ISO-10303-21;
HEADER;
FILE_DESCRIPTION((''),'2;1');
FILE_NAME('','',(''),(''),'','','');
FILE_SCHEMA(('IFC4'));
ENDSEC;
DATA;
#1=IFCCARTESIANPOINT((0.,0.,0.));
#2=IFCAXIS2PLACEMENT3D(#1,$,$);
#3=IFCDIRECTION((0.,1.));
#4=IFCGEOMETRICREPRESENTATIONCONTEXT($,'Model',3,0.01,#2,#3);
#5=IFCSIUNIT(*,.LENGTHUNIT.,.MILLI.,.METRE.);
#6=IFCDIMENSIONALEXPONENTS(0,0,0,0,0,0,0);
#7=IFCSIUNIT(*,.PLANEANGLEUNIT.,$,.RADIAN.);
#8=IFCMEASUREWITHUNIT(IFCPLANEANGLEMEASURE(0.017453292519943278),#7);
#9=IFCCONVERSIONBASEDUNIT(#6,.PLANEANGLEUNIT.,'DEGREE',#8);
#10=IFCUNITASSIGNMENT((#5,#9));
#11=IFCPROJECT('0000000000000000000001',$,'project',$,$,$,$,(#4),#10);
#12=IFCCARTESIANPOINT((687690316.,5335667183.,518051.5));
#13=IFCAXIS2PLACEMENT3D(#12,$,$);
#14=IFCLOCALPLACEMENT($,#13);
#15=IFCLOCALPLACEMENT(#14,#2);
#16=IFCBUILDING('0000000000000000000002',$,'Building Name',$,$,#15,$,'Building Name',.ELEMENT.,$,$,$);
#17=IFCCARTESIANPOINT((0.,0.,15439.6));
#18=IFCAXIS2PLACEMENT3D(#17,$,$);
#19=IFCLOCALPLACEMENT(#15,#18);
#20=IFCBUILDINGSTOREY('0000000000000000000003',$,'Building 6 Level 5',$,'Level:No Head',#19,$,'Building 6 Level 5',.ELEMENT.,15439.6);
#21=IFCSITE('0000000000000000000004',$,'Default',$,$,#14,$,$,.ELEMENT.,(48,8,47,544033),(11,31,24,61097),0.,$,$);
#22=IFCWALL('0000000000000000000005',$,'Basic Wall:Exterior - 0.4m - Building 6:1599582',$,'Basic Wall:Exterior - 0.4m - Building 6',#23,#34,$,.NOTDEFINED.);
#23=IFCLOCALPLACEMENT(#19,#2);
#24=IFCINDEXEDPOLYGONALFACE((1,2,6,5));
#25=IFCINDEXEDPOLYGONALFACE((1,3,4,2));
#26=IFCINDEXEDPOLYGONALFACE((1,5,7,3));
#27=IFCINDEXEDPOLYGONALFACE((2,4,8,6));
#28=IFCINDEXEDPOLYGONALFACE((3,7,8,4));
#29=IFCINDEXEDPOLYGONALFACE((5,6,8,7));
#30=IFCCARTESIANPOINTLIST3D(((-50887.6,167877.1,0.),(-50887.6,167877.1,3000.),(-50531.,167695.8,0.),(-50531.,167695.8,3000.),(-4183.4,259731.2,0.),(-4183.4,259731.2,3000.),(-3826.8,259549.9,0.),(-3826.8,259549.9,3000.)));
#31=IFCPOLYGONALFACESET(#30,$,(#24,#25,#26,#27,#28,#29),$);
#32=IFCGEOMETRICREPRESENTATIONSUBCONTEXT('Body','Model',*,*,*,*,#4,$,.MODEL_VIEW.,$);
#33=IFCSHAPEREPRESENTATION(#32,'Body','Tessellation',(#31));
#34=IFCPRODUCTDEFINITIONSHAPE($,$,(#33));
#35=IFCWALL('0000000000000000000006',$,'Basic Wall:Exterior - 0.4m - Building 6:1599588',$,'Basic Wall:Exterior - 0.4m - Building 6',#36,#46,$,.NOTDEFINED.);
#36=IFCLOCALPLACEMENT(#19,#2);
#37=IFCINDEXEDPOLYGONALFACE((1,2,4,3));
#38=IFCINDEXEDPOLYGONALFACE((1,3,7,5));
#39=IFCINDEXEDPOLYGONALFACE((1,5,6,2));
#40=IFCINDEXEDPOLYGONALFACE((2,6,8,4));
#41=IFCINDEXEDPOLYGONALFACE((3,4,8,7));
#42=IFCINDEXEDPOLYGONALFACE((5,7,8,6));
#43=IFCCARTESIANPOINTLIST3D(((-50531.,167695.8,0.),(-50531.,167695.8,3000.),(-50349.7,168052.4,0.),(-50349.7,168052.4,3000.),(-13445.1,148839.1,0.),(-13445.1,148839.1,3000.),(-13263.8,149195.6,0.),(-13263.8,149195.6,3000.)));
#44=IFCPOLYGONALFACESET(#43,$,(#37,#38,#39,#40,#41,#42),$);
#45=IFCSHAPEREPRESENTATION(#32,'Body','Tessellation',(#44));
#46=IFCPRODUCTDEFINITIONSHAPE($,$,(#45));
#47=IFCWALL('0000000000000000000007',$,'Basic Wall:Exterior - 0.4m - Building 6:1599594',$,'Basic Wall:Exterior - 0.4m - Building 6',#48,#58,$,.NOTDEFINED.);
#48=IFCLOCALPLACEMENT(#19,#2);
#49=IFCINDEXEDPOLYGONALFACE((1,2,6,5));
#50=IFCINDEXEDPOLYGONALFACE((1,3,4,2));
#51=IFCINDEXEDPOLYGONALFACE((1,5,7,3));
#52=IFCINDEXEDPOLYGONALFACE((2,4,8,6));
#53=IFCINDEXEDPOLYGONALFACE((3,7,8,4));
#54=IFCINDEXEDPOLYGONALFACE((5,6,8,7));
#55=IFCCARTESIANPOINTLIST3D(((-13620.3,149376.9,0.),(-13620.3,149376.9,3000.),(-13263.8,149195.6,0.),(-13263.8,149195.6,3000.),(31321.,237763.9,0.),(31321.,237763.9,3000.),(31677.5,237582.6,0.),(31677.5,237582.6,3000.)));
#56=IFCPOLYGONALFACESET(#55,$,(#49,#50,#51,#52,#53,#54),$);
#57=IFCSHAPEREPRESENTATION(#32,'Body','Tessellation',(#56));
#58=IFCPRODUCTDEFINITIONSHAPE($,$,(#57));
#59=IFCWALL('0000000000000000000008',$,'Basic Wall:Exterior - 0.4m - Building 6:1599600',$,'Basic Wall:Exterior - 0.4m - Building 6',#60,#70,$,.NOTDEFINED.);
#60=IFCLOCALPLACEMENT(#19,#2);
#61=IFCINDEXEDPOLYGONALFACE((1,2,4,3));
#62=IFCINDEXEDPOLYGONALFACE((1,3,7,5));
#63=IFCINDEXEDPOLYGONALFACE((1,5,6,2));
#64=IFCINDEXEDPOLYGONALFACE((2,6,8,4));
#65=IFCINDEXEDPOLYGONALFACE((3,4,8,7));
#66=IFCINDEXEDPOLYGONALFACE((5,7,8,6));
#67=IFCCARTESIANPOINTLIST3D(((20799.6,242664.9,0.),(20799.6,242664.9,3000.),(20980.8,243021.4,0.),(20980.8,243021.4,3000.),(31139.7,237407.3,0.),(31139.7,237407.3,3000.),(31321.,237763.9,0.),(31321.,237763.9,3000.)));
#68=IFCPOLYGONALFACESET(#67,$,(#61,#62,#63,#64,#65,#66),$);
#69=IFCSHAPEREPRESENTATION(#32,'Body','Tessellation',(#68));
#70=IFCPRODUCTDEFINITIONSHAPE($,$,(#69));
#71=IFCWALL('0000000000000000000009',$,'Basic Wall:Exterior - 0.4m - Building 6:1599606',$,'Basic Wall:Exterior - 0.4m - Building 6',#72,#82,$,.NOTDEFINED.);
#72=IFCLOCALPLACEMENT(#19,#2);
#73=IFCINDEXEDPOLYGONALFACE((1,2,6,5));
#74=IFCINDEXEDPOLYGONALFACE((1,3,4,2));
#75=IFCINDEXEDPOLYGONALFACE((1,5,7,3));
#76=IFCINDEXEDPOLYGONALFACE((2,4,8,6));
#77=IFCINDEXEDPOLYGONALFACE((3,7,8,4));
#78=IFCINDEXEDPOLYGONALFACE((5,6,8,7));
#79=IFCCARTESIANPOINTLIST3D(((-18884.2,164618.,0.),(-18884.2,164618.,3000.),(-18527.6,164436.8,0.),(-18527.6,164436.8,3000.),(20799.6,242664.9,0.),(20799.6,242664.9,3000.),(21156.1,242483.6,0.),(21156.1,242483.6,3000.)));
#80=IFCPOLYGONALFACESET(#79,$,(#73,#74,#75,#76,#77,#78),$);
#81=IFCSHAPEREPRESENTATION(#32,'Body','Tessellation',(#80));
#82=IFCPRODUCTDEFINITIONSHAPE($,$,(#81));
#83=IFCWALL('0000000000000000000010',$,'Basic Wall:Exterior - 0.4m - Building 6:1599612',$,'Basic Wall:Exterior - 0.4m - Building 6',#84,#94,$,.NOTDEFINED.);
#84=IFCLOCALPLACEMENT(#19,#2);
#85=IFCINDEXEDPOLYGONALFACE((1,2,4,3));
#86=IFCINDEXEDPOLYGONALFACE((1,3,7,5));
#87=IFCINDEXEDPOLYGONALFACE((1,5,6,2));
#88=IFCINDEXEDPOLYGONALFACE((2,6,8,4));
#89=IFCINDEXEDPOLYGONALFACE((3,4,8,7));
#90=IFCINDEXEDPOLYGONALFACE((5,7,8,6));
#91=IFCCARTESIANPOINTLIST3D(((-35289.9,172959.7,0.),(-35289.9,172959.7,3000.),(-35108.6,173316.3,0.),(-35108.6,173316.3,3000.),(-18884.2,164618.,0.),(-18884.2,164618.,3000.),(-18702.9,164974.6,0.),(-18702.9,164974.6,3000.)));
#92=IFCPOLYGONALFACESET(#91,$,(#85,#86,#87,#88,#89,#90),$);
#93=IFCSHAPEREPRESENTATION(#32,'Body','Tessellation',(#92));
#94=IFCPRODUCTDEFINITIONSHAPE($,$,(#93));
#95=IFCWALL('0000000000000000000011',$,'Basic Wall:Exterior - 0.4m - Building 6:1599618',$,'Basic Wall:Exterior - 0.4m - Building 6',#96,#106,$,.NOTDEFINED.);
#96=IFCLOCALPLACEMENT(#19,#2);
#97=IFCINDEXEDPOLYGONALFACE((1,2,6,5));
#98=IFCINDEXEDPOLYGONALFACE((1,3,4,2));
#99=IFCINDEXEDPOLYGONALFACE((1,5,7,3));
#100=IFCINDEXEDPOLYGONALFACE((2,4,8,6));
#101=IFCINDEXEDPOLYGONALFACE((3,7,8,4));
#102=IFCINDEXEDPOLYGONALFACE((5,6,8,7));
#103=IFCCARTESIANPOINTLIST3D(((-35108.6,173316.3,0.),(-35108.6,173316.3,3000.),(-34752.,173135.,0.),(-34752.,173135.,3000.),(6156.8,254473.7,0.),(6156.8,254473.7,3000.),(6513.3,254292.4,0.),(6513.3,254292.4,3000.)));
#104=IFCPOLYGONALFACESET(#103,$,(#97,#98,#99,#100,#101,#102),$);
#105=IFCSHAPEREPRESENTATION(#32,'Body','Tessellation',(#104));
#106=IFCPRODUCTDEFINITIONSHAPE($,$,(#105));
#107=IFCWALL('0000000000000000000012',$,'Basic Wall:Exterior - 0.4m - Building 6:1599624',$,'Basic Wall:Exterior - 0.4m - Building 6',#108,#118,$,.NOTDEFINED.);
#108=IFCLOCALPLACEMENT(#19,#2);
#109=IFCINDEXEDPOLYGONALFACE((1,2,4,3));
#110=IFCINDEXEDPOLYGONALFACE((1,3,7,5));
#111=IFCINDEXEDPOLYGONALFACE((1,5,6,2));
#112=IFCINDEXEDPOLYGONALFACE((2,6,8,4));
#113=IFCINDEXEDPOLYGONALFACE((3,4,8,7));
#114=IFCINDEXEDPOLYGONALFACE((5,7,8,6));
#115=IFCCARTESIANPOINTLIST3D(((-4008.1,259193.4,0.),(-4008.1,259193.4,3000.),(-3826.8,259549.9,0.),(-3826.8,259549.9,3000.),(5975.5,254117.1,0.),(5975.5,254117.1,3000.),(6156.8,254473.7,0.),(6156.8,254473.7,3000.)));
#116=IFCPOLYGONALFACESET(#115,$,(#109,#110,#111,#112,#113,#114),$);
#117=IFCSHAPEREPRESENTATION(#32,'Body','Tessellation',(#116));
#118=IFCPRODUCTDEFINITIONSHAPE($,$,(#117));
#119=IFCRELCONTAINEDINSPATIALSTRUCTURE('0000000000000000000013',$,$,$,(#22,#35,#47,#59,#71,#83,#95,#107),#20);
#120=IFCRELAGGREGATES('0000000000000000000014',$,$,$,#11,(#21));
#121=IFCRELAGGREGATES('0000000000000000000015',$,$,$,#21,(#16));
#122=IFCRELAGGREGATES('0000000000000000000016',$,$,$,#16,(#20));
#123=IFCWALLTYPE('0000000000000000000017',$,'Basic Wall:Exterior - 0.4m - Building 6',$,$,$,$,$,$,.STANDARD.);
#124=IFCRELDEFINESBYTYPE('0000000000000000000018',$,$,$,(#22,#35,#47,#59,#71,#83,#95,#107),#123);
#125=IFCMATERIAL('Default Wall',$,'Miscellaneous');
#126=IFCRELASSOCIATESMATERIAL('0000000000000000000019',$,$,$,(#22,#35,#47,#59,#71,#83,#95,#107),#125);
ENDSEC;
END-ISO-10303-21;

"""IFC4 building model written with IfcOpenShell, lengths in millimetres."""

from ifc_helpers import new_model, entity, si_unit, converted_unit, direction, frame, origin, place, context, subcontext, project, spatial, indexed_curve, outline, extrude, material, type_object, element, save


model = new_model("IFC4")

# Units and contexts
model_context = context("Model", 3, precision=0.01, world=origin(), true_north=direction((0.0, 1.0)))
body_context = subcontext(model_context, "Body", "Model", "MODEL_VIEW")
ifc_project = project(units=[si_unit("LENGTHUNIT", "METRE", prefix="MILLI"), converted_unit("PLANEANGLEUNIT", "DEGREE", entity("IfcPlaneAngleMeasure", 0.017453292519943278), si_unit("PLANEANGLEUNIT", "RADIAN"), dimensions=[0, 0, 0, 0, 0, 0, 0])], contexts=[model_context])

# Site, building, storey
site_placement = place(None, frame((687690316.0, 5335667183.0, 518051.5)))
site = spatial("IfcSite", under=ifc_project, at=site_placement, Name="Default", CompositionType="ELEMENT", RefLatitude=(48, 8, 47, 544033), RefLongitude=(11, 31, 24, 61097), RefElevation=0.0)
building_placement = place(site_placement, origin())
building = spatial("IfcBuilding", under=site, at=building_placement, Name="Building Name", LongName="Building Name", CompositionType="ELEMENT")
storey_placement = place(building_placement, frame((0.0, 0.0, 15439.6)))
storey = spatial("IfcBuildingStorey", under=building, at=storey_placement, Name="Building 6 Level 5", ObjectType="Level:No Head", LongName="Building 6 Level 5", CompositionType="ELEMENT", Elevation=15439.6)

# Walls
ifc_material_1 = material(Name="Default Wall", Category="Miscellaneous")
wall_type = type_object("IfcWallType", Name="Basic Wall:Exterior - 0.4m - Building 6", PredefinedType="STANDARD")
wall_1_placement = place(storey_placement, frame((-4005.1, 259640.6, 0.0), z_axis=(0.0, 0.0, 1.0), x_axis=(-0.453237, -0.89139, 0.0)))
element("IfcWall", 1, at=wall_1_placement, inside=storey, type_object=wall_type, material=ifc_material_1, Name="Basic Wall:Exterior - 0.4m - Building 6:1599582", ObjectType="Basic Wall:Exterior - 0.4m - Building 6", PredefinedType="NOTDEFINED", context=body_context, shape_type="SweptSolid", body=[
    extrude(outline(indexed_curve([(103045.9, 200.0), (0.0, 200.0), (0.0, -200.0), (103045.9, -200.0), (103045.9, 200.0)], self_intersect=False)), origin(), (0.0, 0.0, 1.0), 3000.0),
])
wall_2_placement = place(storey_placement, frame((-50440.4, 167874.1, 0.0), z_axis=(0.0, 0.0, 1.0), x_axis=(0.89139, -0.453237, 0.0)))
element("IfcWall", 2, at=wall_2_placement, inside=storey, type_object=wall_type, material=ifc_material_1, Name="Basic Wall:Exterior - 0.4m - Building 6:1599588", ObjectType="Basic Wall:Exterior - 0.4m - Building 6", PredefinedType="NOTDEFINED", context=body_context, shape_type="SweptSolid", body=[
    extrude(outline(indexed_curve([(41604.6, 200.0), (0.0, 200.0), (0.0, -200.0), (41604.6, -200.0), (41604.6, 200.0)], self_intersect=False)), origin(), (0.0, 0.0, 1.0), 3000.0),
])
wall_3_placement = place(storey_placement, frame((-13442.0, 149286.3, 0.0), z_axis=(0.0, 0.0, 1.0), x_axis=(0.453237, 0.89139, 0.0)))
element("IfcWall", 3, at=wall_3_placement, inside=storey, type_object=wall_type, material=ifc_material_1, Name="Basic Wall:Exterior - 0.4m - Building 6:1599594", ObjectType="Basic Wall:Exterior - 0.4m - Building 6", PredefinedType="NOTDEFINED", context=body_context, shape_type="SweptSolid", body=[
    extrude(outline(indexed_curve([(99156.3, 200.0), (0.0, 200.0), (0.0, -200.0), (99156.3, -200.0), (99156.3, 200.0)], self_intersect=False)), origin(), (0.0, 0.0, 1.0), 3000.0),
])
wall_4_placement = place(storey_placement, frame((31230.3, 237585.6, 0.0), z_axis=(0.0, 0.0, 1.0), x_axis=(-0.89139, 0.453237, 0.0)))
element("IfcWall", 4, at=wall_4_placement, inside=storey, type_object=wall_type, material=ifc_material_1, Name="Basic Wall:Exterior - 0.4m - Building 6:1599600", ObjectType="Basic Wall:Exterior - 0.4m - Building 6", PredefinedType="NOTDEFINED", context=body_context, shape_type="SweptSolid", body=[
    extrude(outline(indexed_curve([(11600.0, 200.0), (0.0, 200.0), (0.0, -200.0), (11600.0, -200.0), (11600.0, 200.0)], self_intersect=False)), origin(), (0.0, 0.0, 1.0), 3000.0),
])
wall_5_placement = place(storey_placement, frame((20977.8, 242574.2, 0.0), z_axis=(0.0, 0.0, 1.0), x_axis=(-0.453237, -0.89139, 0.0)))
element("IfcWall", 5, at=wall_5_placement, inside=storey, type_object=wall_type, material=ifc_material_1, Name="Basic Wall:Exterior - 0.4m - Building 6:1599606", ObjectType="Basic Wall:Exterior - 0.4m - Building 6", PredefinedType="NOTDEFINED", context=body_context, shape_type="SweptSolid", body=[
    extrude(outline(indexed_curve([(87556.3, 200.0), (0.0, 200.0), (0.0, -200.0), (87556.3, -200.0), (87556.3, 200.0)], self_intersect=False)), origin(), (0.0, 0.0, 1.0), 3000.0),
])
wall_6_placement = place(storey_placement, frame((-18793.5, 164796.3, 0.0), z_axis=(0.0, 0.0, 1.0), x_axis=(-0.89139, 0.453237, 0.0)))
element("IfcWall", 6, at=wall_6_placement, inside=storey, type_object=wall_type, material=ifc_material_1, Name="Basic Wall:Exterior - 0.4m - Building 6:1599612", ObjectType="Basic Wall:Exterior - 0.4m - Building 6", PredefinedType="NOTDEFINED", context=body_context, shape_type="SweptSolid", body=[
    extrude(outline(indexed_curve([(18404.6, 200.0), (0.0, 200.0), (0.0, -200.0), (18404.6, -200.0), (18404.6, 200.0)], self_intersect=False)), origin(), (0.0, 0.0, 1.0), 3000.0),
])
wall_7_placement = place(storey_placement, frame((-34930.3, 173225.6, 0.0), z_axis=(0.0, 0.0, 1.0), x_axis=(0.453237, 0.89139, 0.0)))
element("IfcWall", 7, at=wall_7_placement, inside=storey, type_object=wall_type, material=ifc_material_1, Name="Basic Wall:Exterior - 0.4m - Building 6:1599618", ObjectType="Basic Wall:Exterior - 0.4m - Building 6", PredefinedType="NOTDEFINED", context=body_context, shape_type="SweptSolid", body=[
    extrude(outline(indexed_curve([(91045.9, 200.0), (0.0, 200.0), (0.0, -200.0), (91045.9, -200.0), (91045.9, 200.0)], self_intersect=False)), origin(), (0.0, 0.0, 1.0), 3000.0),
])
wall_8_placement = place(storey_placement, frame((6066.1, 254295.4, 0.0), z_axis=(0.0, 0.0, 1.0), x_axis=(-0.89139, 0.453237, 0.0)))
element("IfcWall", 8, at=wall_8_placement, inside=storey, type_object=wall_type, material=ifc_material_1, Name="Basic Wall:Exterior - 0.4m - Building 6:1599624", ObjectType="Basic Wall:Exterior - 0.4m - Building 6", PredefinedType="NOTDEFINED", context=body_context, shape_type="SweptSolid", body=[
    extrude(outline(indexed_curve([(11200.0, 200.0), (0.0, 200.0), (0.0, -200.0), (11200.0, -200.0), (11200.0, 200.0)], self_intersect=False)), origin(), (0.0, 0.0, 1.0), 3000.0),
])

save(model, "model.ifc")
